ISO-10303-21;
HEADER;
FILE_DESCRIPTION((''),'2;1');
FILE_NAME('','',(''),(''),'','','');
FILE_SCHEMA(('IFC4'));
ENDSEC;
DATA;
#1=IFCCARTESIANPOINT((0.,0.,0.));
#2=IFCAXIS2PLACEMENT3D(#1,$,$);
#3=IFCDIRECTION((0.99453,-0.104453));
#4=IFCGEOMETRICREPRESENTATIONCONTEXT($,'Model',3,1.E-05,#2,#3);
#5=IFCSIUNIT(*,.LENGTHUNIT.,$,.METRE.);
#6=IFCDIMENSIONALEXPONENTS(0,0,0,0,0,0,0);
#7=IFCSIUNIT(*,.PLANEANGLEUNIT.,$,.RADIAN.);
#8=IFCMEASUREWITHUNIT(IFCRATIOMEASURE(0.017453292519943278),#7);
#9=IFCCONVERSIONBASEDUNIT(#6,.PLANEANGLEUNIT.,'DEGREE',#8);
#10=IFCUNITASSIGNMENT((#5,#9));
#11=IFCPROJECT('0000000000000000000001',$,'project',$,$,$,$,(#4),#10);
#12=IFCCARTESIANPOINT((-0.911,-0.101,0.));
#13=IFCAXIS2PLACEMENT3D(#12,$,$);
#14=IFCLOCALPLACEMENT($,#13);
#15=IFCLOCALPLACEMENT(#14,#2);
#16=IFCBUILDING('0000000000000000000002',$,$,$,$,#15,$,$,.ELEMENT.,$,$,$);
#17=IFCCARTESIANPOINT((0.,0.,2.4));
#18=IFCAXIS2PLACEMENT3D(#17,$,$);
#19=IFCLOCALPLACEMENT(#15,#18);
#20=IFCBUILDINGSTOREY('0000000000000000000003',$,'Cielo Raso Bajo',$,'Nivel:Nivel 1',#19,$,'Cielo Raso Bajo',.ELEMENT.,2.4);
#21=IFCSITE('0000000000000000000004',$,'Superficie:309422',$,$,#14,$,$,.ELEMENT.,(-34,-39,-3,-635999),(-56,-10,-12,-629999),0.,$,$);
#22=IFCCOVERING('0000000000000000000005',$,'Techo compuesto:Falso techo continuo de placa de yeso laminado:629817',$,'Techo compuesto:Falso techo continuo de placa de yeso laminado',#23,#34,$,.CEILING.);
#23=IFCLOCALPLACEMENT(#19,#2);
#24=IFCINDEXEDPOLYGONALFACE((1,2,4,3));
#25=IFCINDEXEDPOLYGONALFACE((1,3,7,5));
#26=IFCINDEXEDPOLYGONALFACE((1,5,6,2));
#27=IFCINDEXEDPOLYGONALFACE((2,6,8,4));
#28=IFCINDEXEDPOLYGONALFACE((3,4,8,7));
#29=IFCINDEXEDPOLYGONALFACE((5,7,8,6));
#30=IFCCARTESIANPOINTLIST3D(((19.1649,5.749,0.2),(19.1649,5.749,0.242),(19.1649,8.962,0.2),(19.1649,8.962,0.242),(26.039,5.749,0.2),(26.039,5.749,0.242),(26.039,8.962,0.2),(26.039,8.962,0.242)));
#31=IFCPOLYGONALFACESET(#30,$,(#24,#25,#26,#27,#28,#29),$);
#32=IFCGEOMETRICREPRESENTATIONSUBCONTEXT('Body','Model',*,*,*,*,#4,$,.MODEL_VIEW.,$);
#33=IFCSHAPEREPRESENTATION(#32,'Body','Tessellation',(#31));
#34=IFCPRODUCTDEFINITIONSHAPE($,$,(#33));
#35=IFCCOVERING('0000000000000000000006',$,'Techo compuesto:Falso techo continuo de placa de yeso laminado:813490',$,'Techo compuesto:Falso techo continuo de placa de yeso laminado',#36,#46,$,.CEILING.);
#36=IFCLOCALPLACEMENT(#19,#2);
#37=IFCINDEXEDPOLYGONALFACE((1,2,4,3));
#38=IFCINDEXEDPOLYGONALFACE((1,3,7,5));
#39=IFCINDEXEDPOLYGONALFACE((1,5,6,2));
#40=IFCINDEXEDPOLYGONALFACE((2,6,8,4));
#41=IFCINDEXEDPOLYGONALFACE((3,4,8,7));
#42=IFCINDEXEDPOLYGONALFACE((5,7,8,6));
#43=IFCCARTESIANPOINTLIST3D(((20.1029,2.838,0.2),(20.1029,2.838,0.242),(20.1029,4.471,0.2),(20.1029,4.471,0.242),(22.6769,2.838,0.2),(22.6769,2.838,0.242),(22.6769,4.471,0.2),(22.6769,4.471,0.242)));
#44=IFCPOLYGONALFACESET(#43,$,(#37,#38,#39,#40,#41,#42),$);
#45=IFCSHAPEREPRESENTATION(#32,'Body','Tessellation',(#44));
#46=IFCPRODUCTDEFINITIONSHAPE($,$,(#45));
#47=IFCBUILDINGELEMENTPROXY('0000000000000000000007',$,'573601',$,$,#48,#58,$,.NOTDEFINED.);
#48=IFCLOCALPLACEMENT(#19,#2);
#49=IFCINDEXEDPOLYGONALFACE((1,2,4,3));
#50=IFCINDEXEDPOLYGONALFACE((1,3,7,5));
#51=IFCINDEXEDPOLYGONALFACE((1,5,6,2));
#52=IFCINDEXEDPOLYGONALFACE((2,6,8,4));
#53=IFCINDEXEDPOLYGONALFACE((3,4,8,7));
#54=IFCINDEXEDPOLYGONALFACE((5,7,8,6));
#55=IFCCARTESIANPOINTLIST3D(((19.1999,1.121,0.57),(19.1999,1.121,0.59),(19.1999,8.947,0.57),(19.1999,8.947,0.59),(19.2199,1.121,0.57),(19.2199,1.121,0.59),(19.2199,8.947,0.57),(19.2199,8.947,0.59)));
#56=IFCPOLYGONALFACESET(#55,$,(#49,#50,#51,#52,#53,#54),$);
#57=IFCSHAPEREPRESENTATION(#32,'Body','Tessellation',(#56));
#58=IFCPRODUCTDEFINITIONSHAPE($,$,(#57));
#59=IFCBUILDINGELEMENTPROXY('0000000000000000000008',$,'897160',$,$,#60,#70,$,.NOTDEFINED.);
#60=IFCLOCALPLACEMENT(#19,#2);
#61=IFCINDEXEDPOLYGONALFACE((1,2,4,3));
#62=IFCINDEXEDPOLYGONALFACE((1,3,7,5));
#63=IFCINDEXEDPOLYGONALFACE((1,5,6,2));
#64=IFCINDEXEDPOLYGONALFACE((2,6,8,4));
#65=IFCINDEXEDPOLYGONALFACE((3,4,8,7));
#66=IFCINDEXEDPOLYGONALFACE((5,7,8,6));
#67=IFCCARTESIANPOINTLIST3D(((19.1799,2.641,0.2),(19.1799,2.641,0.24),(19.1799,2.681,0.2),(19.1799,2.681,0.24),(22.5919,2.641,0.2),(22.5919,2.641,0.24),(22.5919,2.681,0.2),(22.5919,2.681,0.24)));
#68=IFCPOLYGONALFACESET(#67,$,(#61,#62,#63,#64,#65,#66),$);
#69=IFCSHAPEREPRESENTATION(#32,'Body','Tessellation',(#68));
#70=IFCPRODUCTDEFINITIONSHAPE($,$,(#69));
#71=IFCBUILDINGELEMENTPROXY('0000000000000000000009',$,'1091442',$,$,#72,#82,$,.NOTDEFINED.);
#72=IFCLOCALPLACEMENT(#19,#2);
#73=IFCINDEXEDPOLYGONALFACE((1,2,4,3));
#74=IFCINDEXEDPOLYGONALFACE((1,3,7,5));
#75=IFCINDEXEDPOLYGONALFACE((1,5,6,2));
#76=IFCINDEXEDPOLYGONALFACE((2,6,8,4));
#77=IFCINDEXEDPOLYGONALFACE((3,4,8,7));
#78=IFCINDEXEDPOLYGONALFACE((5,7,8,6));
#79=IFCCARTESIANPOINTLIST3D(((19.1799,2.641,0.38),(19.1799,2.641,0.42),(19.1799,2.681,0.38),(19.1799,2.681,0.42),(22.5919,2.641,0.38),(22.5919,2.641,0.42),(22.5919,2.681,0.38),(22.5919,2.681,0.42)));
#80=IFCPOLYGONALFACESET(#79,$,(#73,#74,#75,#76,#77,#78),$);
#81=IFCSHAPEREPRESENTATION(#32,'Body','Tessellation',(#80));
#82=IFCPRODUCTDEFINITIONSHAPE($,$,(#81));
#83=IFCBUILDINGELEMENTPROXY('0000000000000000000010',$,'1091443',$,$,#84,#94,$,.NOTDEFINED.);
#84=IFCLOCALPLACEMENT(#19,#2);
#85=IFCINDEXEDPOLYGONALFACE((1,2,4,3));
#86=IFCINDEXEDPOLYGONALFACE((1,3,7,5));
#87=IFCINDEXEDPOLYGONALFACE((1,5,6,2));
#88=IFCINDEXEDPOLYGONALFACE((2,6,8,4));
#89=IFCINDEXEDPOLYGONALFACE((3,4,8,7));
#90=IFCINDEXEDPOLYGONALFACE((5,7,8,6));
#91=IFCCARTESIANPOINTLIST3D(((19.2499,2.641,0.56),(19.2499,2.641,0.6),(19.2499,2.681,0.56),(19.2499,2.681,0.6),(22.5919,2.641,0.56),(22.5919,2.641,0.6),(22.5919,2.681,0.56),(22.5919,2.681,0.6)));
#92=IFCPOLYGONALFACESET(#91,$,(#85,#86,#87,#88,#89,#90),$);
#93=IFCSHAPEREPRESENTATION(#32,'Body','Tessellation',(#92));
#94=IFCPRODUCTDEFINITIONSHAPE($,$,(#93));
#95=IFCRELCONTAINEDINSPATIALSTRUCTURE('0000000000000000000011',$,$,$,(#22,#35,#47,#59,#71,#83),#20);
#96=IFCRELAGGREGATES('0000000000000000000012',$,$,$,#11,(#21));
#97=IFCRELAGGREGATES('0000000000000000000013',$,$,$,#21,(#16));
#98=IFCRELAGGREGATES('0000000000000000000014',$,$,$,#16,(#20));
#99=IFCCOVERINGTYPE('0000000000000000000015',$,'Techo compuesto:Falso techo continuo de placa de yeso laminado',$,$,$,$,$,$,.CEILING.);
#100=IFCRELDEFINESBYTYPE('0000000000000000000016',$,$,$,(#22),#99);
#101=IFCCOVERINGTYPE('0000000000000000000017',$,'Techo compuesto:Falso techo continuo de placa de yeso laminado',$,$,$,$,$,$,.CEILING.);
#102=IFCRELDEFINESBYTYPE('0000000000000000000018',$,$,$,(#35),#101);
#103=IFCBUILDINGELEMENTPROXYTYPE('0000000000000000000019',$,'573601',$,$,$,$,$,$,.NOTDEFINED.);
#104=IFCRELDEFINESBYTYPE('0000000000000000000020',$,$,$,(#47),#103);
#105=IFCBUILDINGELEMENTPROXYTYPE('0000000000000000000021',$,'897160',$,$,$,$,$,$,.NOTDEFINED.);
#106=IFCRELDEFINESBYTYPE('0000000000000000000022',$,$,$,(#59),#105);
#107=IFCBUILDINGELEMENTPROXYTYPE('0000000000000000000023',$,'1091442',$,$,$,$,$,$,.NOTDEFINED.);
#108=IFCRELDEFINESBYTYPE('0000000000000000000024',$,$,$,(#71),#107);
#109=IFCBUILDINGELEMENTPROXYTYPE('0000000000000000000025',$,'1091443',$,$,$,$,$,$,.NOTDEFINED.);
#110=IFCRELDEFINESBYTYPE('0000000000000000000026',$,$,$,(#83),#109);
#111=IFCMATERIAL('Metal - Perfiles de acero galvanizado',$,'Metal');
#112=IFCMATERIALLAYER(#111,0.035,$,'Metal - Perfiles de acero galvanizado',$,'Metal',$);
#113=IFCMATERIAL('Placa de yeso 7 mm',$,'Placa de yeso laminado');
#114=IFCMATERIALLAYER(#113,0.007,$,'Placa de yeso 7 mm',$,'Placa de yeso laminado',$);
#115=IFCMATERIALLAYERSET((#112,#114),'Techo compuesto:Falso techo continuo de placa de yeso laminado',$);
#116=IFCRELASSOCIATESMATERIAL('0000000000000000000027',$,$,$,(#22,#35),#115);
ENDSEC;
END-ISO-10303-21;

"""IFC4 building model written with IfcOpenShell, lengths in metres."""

from ifc_helpers import new_model, entity, si_unit, converted_unit, direction, frame, frame_2d, origin, place, context, subcontext, project, spatial, rectangle, extrude, material, layer, layer_set, layer_usage, type_object, element, save


model = new_model("IFC4")

# Units and contexts
model_context = context("Model", 3, precision=1e-05, world=origin(), true_north=direction((0.99453, -0.104453)))
body_context = subcontext(model_context, "Body", "Model", "MODEL_VIEW")
ifc_project = project(units=[si_unit("LENGTHUNIT", "METRE"), converted_unit("PLANEANGLEUNIT", "DEGREE", entity("IfcRatioMeasure", 0.017453292519943278), si_unit("PLANEANGLEUNIT", "RADIAN"), dimensions=[0, 0, 0, 0, 0, 0, 0])], contexts=[model_context])

# Site, building, storey
site_placement = place(None, frame((-0.911, -0.101, 0.0)))
site = spatial("IfcSite", under=ifc_project, at=site_placement, Name="Superficie:309422", CompositionType="ELEMENT", RefLatitude=(-34, -39, -3, -635999), RefLongitude=(-56, -10, -12, -629999), RefElevation=0.0)
building_placement = place(site_placement, origin())
building = spatial("IfcBuilding", under=site, at=building_placement, CompositionType="ELEMENT")
storey_placement = place(building_placement, frame((0.0, 0.0, 2.4)))
storey = spatial("IfcBuildingStorey", under=building, at=storey_placement, Name="Cielo Raso Bajo", ObjectType="Nivel:Nivel 1", LongName="Cielo Raso Bajo", CompositionType="ELEMENT", Elevation=2.4)

# Coverings
ifc_material_1 = material(Name="Metal - Perfiles de acero galvanizado", Category="Metal")
ifc_layer_1 = layer(ifc_material_1, 0.035, Name="Metal - Perfiles de acero galvanizado", Category="Metal")
ifc_material_2 = material(Name="Placa de yeso 7 mm", Category="Placa de yeso laminado")
ifc_layer_2 = layer(ifc_material_2, 0.007, Name="Placa de yeso 7 mm", Category="Placa de yeso laminado")
ifc_layer_set_1 = layer_set([ifc_layer_1, ifc_layer_2], Name="Techo compuesto:Falso techo continuo de placa de yeso laminado")
ifc_layer_usage_1 = layer_usage(ifc_layer_set_1, "AXIS3", "POSITIVE", 0.0)
covering_type_1 = type_object("IfcCoveringType", Name="Techo compuesto:Falso techo continuo de placa de yeso laminado", PredefinedType="CEILING")
covering_1_placement = place(storey_placement, frame((19.1649, 5.749, 0.2)))
element("IfcCovering", 1, at=covering_1_placement, inside=storey, type_object=covering_type_1, material=ifc_layer_usage_1, Name="Techo compuesto:Falso techo continuo de placa de yeso laminado:629817", ObjectType="Techo compuesto:Falso techo continuo de placa de yeso laminado", PredefinedType="CEILING", context=body_context, shape_type="SweptSolid", body=[
    extrude(rectangle(XDim=3.213, YDim=6.874, at=frame_2d((0.0, -0.6068), x_axis=(1.0, 0.0))), frame((2.8302, 1.6065, 0.0), z_axis=(0.0, 0.0, 1.0), x_axis=(0.0, 1.0, 0.0)), (0.0, 0.0, 1.0), 0.042),
])
ifc_layer_usage_2 = layer_usage(ifc_layer_set_1, "AXIS3", "POSITIVE", 0.0)
covering_type_2 = type_object("IfcCoveringType", Name="Techo compuesto:Falso techo continuo de placa de yeso laminado", PredefinedType="CEILING")
covering_2_placement = place(storey_placement, frame((20.1029, 2.838, 0.2)))
element("IfcCovering", 2, at=covering_2_placement, inside=storey, type_object=covering_type_2, material=ifc_layer_usage_2, Name="Techo compuesto:Falso techo continuo de placa de yeso laminado:813490", ObjectType="Techo compuesto:Falso techo continuo de placa de yeso laminado", PredefinedType="CEILING", context=body_context, shape_type="SweptSolid", body=[
    extrude(rectangle(XDim=1.633, YDim=2.574, at=frame_2d((0.0, 0.0), x_axis=(1.0, 0.0))), frame((1.287, 0.8165, 0.0), z_axis=(0.0, 0.0, 1.0), x_axis=(0.0, 1.0, 0.0)), (0.0, 0.0, 1.0), 0.042),
])

# Building element proxies
building_element_proxy_type_1 = type_object("IfcBuildingElementProxyType", Name="573601", PredefinedType="NOTDEFINED")
proxy_1_placement = place(storey_placement, frame((19.1999, 1.121, 0.57)))
element("IfcBuildingElementProxy", 3, at=proxy_1_placement, inside=storey, type_object=building_element_proxy_type_1, Name="573601", PredefinedType="NOTDEFINED", context=body_context, shape_type="SweptSolid", body=[
    extrude(rectangle(XDim=7.826, YDim=0.02, at=frame_2d((0.0, 0.0), x_axis=(1.0, 0.0))), frame((0.01, 3.913, 0.0), z_axis=(0.0, 0.0, 1.0), x_axis=(0.0, -1.0, 0.0)), (0.0, 0.0, 1.0), 0.02),
])
building_element_proxy_type_2 = type_object("IfcBuildingElementProxyType", Name="897160", PredefinedType="NOTDEFINED")
proxy_2_placement = place(storey_placement, frame((19.1799, 2.641, 0.2)))
element("IfcBuildingElementProxy", 4, at=proxy_2_placement, inside=storey, type_object=building_element_proxy_type_2, Name="897160", PredefinedType="NOTDEFINED", context=body_context, shape_type="SweptSolid", body=[
    extrude(rectangle(XDim=3.412, YDim=0.04, at=frame_2d((-0.5453, 0.0), x_axis=(1.0, 0.0))), frame((1.1607, 0.02, 0.0), z_axis=(0.0, 0.0, 1.0), x_axis=(-1.0, 0.0, 0.0)), (0.0, 0.0, 1.0), 0.04),
])
building_element_proxy_type_3 = type_object("IfcBuildingElementProxyType", Name="1091442", PredefinedType="NOTDEFINED")
proxy_3_placement = place(storey_placement, frame((19.1799, 2.641, 0.38)))
element("IfcBuildingElementProxy", 5, at=proxy_3_placement, inside=storey, type_object=building_element_proxy_type_3, Name="1091442", PredefinedType="NOTDEFINED", context=body_context, shape_type="SweptSolid", body=[
    extrude(rectangle(XDim=3.412, YDim=0.04, at=frame_2d((0.0, 0.0), x_axis=(1.0, 0.0))), frame((1.706, 0.02, 0.0), z_axis=(0.0, 0.0, 1.0), x_axis=(-1.0, 0.0, 0.0)), (0.0, 0.0, 1.0), 0.04),
])
building_element_proxy_type_4 = type_object("IfcBuildingElementProxyType", Name="1091443", PredefinedType="NOTDEFINED")
proxy_4_placement = place(storey_placement, frame((19.2499, 2.641, 0.56)))
element("IfcBuildingElementProxy", 6, at=proxy_4_placement, inside=storey, type_object=building_element_proxy_type_4, Name="1091443", PredefinedType="NOTDEFINED", context=body_context, shape_type="SweptSolid", body=[
    extrude(rectangle(XDim=3.342, YDim=0.04, at=frame_2d((0.0, 0.0), x_axis=(1.0, 0.0))), frame((1.671, 0.02, 0.0), z_axis=(0.0, 0.0, 1.0), x_axis=(-1.0, 0.0, 0.0)), (0.0, 0.0, 1.0), 0.04),
])

save(model, "model.ifc")
